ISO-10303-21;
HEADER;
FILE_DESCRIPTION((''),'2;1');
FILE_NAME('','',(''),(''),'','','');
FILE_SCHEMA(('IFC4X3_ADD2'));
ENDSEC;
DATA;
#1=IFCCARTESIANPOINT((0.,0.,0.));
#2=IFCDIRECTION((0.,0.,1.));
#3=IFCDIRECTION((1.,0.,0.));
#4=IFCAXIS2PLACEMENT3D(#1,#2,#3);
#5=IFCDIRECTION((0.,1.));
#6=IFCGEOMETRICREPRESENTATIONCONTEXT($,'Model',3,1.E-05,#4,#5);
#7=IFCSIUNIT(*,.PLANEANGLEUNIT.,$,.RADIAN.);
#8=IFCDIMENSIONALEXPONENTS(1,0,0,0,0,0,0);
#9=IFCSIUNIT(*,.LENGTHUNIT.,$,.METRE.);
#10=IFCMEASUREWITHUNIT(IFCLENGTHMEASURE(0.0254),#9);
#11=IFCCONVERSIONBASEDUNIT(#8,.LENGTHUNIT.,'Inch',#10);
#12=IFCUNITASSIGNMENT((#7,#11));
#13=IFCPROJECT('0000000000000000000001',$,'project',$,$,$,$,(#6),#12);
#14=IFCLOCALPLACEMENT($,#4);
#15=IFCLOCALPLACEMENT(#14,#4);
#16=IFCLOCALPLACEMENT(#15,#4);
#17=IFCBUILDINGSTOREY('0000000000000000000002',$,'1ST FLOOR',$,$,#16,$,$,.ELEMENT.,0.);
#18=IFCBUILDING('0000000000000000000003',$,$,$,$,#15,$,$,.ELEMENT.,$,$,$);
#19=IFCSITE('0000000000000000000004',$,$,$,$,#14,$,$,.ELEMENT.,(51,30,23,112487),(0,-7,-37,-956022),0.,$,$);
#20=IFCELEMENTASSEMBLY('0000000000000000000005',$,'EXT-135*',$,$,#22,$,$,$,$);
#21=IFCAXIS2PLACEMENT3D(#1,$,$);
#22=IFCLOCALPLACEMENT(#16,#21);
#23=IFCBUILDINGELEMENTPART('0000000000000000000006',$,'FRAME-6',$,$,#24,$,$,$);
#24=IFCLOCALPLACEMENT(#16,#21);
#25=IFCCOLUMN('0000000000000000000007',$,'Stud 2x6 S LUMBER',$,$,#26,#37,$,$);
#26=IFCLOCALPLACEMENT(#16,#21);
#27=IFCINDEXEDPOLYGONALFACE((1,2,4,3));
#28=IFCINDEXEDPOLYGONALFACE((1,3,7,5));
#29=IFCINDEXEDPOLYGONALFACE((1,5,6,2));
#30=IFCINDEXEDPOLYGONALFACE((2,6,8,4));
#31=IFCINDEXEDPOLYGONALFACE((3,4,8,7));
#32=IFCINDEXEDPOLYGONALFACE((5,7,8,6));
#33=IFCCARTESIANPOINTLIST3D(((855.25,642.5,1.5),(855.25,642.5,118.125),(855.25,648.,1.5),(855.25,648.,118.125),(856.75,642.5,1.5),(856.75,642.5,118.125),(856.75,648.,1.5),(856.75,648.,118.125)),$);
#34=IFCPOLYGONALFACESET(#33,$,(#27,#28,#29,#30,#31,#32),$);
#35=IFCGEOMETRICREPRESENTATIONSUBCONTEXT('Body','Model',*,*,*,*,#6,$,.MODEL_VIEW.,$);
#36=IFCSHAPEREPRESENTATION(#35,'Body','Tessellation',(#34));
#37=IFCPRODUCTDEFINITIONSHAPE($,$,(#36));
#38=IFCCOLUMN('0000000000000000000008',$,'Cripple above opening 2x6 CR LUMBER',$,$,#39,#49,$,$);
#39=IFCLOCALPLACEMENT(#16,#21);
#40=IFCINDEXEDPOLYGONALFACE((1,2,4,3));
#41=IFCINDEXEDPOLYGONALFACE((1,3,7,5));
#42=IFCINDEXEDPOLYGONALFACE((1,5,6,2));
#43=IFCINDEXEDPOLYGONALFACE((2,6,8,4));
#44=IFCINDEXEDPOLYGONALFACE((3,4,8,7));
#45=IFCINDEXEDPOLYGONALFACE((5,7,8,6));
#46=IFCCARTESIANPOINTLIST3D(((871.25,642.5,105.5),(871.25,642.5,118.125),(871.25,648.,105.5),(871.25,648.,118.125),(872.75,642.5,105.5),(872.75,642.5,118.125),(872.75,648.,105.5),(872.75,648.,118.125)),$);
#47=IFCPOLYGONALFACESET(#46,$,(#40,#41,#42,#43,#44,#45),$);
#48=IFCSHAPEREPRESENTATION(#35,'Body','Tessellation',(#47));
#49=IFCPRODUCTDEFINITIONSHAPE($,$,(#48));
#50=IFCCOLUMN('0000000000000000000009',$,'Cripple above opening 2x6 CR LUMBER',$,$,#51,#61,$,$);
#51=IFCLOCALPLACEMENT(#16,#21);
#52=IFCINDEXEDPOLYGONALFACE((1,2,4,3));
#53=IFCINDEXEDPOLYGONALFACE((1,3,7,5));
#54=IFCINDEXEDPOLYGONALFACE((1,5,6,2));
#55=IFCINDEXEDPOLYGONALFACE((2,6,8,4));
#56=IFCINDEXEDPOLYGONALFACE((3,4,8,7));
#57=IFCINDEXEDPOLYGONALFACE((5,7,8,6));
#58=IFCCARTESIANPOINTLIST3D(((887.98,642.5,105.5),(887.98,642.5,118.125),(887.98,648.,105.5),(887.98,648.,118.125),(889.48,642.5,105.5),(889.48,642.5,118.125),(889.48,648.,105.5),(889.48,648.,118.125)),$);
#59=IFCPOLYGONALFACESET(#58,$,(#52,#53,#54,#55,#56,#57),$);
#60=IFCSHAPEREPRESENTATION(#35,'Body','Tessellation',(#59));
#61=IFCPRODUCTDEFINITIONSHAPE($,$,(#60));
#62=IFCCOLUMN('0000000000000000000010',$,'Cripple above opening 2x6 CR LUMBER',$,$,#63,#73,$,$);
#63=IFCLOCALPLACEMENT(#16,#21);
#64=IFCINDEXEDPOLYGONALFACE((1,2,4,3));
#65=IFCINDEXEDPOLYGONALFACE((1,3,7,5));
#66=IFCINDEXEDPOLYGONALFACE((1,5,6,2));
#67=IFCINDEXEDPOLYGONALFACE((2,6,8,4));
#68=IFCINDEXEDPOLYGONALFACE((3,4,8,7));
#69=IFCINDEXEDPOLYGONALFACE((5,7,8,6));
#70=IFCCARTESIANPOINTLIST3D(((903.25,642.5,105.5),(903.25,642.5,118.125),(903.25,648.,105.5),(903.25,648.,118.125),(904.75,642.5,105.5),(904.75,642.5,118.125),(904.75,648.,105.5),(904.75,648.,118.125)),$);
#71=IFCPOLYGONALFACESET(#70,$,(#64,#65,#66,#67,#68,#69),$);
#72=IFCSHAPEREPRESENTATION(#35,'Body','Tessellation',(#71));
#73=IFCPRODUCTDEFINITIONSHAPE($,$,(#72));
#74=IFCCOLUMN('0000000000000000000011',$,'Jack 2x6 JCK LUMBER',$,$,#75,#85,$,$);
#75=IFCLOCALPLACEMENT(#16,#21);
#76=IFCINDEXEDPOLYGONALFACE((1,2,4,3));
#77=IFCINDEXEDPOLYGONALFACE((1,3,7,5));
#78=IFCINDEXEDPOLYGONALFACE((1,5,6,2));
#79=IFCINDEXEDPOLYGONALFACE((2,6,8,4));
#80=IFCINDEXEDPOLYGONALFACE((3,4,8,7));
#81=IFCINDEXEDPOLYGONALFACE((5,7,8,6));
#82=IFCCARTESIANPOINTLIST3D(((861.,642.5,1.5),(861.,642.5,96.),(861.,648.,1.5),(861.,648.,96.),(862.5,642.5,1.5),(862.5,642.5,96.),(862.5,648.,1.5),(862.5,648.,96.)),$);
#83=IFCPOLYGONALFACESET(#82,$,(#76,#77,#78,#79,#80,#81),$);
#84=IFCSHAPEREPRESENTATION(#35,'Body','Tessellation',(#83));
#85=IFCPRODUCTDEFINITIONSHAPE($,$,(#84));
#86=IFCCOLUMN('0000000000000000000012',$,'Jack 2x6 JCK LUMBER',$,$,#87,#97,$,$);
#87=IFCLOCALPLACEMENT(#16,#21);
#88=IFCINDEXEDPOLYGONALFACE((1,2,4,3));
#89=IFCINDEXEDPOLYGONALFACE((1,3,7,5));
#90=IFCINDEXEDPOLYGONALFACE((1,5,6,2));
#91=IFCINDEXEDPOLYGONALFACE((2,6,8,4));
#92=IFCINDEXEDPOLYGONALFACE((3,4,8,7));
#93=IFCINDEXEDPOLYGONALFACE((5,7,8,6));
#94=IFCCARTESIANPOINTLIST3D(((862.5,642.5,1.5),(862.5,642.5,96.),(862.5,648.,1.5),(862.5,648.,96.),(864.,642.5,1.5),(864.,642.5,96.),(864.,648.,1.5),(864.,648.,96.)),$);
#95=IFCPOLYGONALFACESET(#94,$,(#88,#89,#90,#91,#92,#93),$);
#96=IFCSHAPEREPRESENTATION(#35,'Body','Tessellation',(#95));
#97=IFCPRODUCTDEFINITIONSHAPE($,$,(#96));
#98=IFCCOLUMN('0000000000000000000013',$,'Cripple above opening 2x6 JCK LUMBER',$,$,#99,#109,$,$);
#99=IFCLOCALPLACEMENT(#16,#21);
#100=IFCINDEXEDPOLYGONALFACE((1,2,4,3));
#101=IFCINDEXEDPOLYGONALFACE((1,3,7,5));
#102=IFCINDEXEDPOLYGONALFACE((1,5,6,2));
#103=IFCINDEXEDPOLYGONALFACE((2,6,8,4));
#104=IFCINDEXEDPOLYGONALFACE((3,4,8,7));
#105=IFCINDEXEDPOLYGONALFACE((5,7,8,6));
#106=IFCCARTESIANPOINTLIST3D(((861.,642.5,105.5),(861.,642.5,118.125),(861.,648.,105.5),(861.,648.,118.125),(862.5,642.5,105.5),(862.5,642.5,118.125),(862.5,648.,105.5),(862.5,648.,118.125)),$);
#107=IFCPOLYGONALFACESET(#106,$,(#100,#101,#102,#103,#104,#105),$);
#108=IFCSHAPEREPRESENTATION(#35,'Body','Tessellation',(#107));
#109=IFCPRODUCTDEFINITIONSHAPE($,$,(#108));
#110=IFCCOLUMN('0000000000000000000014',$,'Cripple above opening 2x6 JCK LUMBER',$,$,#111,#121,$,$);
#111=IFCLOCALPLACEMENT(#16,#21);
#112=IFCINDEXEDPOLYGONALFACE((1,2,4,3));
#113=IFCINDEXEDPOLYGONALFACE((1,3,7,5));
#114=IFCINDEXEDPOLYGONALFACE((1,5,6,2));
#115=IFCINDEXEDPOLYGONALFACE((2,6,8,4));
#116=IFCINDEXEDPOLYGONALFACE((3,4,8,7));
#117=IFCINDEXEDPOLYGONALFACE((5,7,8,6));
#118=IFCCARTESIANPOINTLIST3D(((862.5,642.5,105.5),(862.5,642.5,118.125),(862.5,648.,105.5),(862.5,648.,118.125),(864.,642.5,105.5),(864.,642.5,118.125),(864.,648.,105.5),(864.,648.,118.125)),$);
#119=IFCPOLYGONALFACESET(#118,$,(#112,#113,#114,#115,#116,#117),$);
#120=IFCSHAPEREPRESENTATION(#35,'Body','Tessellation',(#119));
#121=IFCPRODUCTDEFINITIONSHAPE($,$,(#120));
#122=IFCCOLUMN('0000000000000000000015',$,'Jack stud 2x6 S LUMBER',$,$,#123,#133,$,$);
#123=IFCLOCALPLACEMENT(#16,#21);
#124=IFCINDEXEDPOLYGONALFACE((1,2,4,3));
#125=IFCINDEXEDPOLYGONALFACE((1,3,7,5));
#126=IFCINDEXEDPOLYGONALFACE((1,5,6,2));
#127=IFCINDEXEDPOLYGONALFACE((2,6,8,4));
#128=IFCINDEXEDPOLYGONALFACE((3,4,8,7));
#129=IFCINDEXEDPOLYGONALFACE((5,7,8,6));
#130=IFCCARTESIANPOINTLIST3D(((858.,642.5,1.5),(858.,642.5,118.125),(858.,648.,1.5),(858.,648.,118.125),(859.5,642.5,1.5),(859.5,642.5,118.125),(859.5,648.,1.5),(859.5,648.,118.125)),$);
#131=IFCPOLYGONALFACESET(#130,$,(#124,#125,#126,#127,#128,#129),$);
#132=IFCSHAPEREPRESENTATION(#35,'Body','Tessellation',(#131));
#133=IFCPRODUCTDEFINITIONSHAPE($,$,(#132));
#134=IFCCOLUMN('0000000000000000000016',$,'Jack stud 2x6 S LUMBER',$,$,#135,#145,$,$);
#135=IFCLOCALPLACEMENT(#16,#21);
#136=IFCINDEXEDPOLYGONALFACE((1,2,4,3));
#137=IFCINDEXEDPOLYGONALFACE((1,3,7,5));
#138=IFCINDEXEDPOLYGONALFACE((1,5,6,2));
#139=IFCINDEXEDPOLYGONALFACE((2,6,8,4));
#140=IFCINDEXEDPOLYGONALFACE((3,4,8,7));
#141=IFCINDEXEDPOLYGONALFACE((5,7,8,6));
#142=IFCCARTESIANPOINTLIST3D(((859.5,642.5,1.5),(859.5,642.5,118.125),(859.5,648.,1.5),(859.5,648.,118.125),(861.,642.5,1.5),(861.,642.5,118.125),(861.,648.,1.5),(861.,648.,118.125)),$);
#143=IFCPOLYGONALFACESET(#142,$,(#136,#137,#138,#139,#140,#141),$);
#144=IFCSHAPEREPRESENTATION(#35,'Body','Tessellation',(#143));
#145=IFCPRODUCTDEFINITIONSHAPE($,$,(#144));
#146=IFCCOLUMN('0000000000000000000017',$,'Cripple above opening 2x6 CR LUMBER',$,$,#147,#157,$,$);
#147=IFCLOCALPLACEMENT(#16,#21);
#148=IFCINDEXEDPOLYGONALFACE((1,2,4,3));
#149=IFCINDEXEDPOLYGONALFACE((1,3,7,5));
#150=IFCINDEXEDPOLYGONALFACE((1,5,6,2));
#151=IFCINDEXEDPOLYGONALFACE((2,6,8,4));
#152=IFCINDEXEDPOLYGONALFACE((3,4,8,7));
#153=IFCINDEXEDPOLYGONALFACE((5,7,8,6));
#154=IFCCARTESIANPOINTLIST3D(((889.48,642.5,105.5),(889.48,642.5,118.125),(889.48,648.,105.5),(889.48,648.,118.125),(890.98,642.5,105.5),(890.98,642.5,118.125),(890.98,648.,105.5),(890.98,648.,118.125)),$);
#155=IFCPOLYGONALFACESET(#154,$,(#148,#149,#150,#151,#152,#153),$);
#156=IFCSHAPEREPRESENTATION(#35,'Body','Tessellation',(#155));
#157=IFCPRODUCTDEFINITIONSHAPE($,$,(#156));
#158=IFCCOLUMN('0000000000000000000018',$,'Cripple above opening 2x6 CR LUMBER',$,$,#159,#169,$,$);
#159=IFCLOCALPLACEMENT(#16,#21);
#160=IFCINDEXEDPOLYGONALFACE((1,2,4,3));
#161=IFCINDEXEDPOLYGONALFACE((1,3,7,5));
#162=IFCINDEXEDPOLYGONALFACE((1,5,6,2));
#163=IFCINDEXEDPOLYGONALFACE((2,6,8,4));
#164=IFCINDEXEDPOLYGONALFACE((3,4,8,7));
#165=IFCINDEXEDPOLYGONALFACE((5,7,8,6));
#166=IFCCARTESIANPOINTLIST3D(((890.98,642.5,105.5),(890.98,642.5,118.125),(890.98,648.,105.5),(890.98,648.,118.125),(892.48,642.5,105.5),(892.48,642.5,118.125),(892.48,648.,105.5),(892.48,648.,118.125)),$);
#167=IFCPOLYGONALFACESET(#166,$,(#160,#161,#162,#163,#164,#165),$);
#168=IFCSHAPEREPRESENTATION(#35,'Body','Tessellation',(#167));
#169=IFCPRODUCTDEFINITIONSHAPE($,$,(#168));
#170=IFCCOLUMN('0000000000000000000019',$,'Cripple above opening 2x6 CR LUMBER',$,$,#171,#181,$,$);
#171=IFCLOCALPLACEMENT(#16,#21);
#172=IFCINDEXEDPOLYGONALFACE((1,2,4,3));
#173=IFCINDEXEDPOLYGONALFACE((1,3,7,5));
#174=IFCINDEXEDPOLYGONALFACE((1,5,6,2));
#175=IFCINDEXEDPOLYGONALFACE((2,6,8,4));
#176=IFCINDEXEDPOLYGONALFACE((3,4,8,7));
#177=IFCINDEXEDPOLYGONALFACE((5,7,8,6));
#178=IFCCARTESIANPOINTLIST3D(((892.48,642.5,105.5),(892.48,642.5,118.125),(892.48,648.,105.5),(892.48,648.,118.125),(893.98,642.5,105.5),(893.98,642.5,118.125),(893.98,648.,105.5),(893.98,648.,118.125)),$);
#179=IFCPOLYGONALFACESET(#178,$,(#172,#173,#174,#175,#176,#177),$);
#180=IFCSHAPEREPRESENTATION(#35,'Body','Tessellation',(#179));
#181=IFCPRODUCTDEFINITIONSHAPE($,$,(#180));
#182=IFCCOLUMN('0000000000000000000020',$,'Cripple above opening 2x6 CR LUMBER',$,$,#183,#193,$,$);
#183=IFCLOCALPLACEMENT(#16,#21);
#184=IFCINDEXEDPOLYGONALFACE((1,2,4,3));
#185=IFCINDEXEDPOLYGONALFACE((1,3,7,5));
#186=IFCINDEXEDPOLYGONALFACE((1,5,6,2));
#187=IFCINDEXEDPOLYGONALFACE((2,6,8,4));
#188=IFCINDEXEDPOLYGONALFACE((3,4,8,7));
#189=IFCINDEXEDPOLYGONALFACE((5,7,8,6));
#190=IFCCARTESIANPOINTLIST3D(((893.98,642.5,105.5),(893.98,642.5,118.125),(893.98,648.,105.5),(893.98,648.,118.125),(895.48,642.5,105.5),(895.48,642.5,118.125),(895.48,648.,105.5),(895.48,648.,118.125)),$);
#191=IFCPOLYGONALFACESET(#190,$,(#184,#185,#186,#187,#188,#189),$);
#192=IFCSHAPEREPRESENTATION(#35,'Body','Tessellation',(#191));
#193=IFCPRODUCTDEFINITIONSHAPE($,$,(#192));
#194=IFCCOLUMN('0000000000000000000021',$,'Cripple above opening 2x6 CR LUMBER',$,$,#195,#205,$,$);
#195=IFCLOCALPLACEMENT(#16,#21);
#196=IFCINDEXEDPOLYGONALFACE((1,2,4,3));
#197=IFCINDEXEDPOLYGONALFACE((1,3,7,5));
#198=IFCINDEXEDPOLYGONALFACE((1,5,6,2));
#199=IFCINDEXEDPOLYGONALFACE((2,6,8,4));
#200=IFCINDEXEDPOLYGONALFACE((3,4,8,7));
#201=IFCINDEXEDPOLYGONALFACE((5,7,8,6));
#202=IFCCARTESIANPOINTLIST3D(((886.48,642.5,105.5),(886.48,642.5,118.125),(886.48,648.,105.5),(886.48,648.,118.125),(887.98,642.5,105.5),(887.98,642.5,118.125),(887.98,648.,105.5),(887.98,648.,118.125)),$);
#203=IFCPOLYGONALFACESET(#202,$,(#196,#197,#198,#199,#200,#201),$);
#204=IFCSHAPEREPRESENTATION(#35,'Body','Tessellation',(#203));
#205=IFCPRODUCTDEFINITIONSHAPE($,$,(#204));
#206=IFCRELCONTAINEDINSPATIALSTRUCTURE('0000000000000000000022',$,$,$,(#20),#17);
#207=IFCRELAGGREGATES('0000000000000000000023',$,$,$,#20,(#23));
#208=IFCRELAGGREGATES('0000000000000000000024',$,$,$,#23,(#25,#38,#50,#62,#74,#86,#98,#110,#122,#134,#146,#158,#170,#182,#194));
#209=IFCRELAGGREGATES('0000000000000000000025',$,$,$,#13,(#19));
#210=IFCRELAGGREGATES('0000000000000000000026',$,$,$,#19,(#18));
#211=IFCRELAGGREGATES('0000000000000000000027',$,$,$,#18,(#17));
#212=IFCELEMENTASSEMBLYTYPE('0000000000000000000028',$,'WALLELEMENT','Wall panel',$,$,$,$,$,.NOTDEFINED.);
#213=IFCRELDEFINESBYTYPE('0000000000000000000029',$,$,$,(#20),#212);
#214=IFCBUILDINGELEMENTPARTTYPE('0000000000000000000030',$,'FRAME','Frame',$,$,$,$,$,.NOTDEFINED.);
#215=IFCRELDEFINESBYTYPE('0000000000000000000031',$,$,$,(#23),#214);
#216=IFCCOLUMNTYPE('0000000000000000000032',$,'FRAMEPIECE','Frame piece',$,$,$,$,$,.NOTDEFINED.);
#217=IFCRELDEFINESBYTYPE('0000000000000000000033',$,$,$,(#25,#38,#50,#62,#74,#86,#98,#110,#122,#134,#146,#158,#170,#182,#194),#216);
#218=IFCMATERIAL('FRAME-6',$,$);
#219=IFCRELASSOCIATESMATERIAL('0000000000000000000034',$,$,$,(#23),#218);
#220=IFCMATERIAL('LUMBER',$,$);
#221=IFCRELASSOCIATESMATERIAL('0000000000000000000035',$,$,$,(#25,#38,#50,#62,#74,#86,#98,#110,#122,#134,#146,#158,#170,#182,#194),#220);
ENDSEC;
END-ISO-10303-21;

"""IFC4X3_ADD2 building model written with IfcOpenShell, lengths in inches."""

from ifc_helpers import new_model, entity, si_unit, converted_unit, direction, frame, origin_with_axes, origin_2d_with_axis, place, context, subcontext, project, spatial, rectangle, extrude, material, type_object, element, aggregate, save


model = new_model("IFC4X3_ADD2")

# Units and contexts
model_context = context("Model", 3, precision=1e-05, world=origin_with_axes(), true_north=direction((0.0, 1.0)))
body_context = subcontext(model_context, "Body", "Model", "MODEL_VIEW")
ifc_project = project(units=[si_unit("PLANEANGLEUNIT", "RADIAN"), converted_unit("LENGTHUNIT", "Inch", entity("IfcLengthMeasure", 0.0254), si_unit("LENGTHUNIT", "METRE"), dimensions=[1, 0, 0, 0, 0, 0, 0])], contexts=[model_context])

# Site, building, storey
site_placement = place(None, origin_with_axes())
site = spatial("IfcSite", under=ifc_project, at=site_placement, CompositionType="ELEMENT", RefLatitude=(51, 30, 23, 112487), RefLongitude=(0, -7, -37, -956022), RefElevation=0.0)
building_placement = place(site_placement, origin_with_axes())
building = spatial("IfcBuilding", under=site, at=building_placement, CompositionType="ELEMENT")
storey_placement = place(building_placement, origin_with_axes())
storey = spatial("IfcBuildingStorey", under=building, at=storey_placement, Name="1ST FLOOR", CompositionType="ELEMENT", Elevation=0.0)

# Element assembly, building element part, columns
element_assembly_type_1 = type_object("IfcElementAssemblyType", Name="WALLELEMENT", Description="Wall panel", PredefinedType="NOTDEFINED")
assembly_1_placement = place(storey_placement, origin_with_axes())
assembly_1 = element("IfcElementAssembly", 1, at=assembly_1_placement, inside=storey, type_object=element_assembly_type_1, Name="EXT-135*")
ifc_material_1 = material(Name="FRAME-6")
building_element_part_type = type_object("IfcBuildingElementPartType", Name="FRAME", Description="Frame", PredefinedType="NOTDEFINED")
building_element_part_1_placement = place(storey_placement, origin_with_axes())
building_element_part_1 = element("IfcBuildingElementPart", 2, at=building_element_part_1_placement, type_object=building_element_part_type, material=ifc_material_1, Name="FRAME-6")
aggregate(assembly_1, [building_element_part_1])
ifc_material_2 = material(Name="LUMBER")
column_type = type_object("IfcColumnType", Name="FRAMEPIECE", Description="Frame piece", PredefinedType="NOTDEFINED")
column_1_placement = place(storey_placement, frame((856.0, 645.25, 118.125), z_axis=(0.0, 0.0, -1.0), x_axis=(-1.0, 0.0, 0.0)))
column_1 = element("IfcColumn", 3, at=column_1_placement, type_object=column_type, material=ifc_material_2, Name="Stud 2x6 S LUMBER", context=body_context, shape_type="SweptSolid", body=[
    extrude(rectangle(XDim=1.5, YDim=5.5, at=origin_2d_with_axis()), origin_with_axes(), (0.0, 0.0, 1.0), 116.625),
])
column_2_placement = place(storey_placement, frame((872.0, 645.25, 118.125), z_axis=(0.0, 0.0, -1.0), x_axis=(-1.0, 0.0, 0.0)))
column_2 = element("IfcColumn", 4, at=column_2_placement, type_object=column_type, material=ifc_material_2, Name="Cripple above opening 2x6 CR LUMBER", context=body_context, shape_type="SweptSolid", body=[
    extrude(rectangle(XDim=1.5, YDim=5.5, at=origin_2d_with_axis()), origin_with_axes(), (0.0, 0.0, 1.0), 12.625),
])
column_3_placement = place(storey_placement, frame((888.73, 645.25, 118.125), z_axis=(0.0, 0.0, -1.0), x_axis=(-1.0, 0.0, 0.0)))
column_3 = element("IfcColumn", 5, at=column_3_placement, type_object=column_type, material=ifc_material_2, Name="Cripple above opening 2x6 CR LUMBER", context=body_context, shape_type="SweptSolid", body=[
    extrude(rectangle(XDim=1.5, YDim=5.5, at=origin_2d_with_axis()), origin_with_axes(), (0.0, 0.0, 1.0), 12.625),
])
column_4_placement = place(storey_placement, frame((904.0, 645.25, 118.125), z_axis=(0.0, 0.0, -1.0), x_axis=(-1.0, 0.0, 0.0)))
column_4 = element("IfcColumn", 6, at=column_4_placement, type_object=column_type, material=ifc_material_2, Name="Cripple above opening 2x6 CR LUMBER", context=body_context, shape_type="SweptSolid", body=[
    extrude(rectangle(XDim=1.5, YDim=5.5, at=origin_2d_with_axis()), origin_with_axes(), (0.0, 0.0, 1.0), 12.625),
])
column_5_placement = place(storey_placement, frame((861.75, 645.25, 1.5), z_axis=(0.0, 0.0, 1.0), x_axis=(1.0, 0.0, 0.0)))
column_5 = element("IfcColumn", 7, at=column_5_placement, type_object=column_type, material=ifc_material_2, Name="Jack 2x6 JCK LUMBER", context=body_context, shape_type="SweptSolid", body=[
    extrude(rectangle(XDim=1.5, YDim=5.5, at=origin_2d_with_axis()), origin_with_axes(), (0.0, 0.0, 1.0), 94.5),
])
column_6_placement = place(storey_placement, frame((863.25, 645.25, 1.5), z_axis=(0.0, 0.0, 1.0), x_axis=(1.0, 0.0, 0.0)))
column_6 = element("IfcColumn", 8, at=column_6_placement, type_object=column_type, material=ifc_material_2, Name="Jack 2x6 JCK LUMBER", context=body_context, shape_type="SweptSolid", body=[
    extrude(rectangle(XDim=1.5, YDim=5.5, at=origin_2d_with_axis()), origin_with_axes(), (0.0, 0.0, 1.0), 94.5),
])
column_7_placement = place(storey_placement, frame((861.75, 645.25, 105.5), z_axis=(0.0, 0.0, 1.0), x_axis=(1.0, 0.0, 0.0)))
column_7 = element("IfcColumn", 9, at=column_7_placement, type_object=column_type, material=ifc_material_2, Name="Cripple above opening 2x6 JCK LUMBER", context=body_context, shape_type="SweptSolid", body=[
    extrude(rectangle(XDim=1.5, YDim=5.5, at=origin_2d_with_axis()), origin_with_axes(), (0.0, 0.0, 1.0), 12.625),
])
column_8_placement = place(storey_placement, frame((863.25, 645.25, 105.5), z_axis=(0.0, 0.0, 1.0), x_axis=(1.0, 0.0, 0.0)))
column_8 = element("IfcColumn", 10, at=column_8_placement, type_object=column_type, material=ifc_material_2, Name="Cripple above opening 2x6 JCK LUMBER", context=body_context, shape_type="SweptSolid", body=[
    extrude(rectangle(XDim=1.5, YDim=5.5, at=origin_2d_with_axis()), origin_with_axes(), (0.0, 0.0, 1.0), 12.625),
])
column_9_placement = place(storey_placement, frame((858.75, 645.25, 1.5), z_axis=(0.0, 0.0, 1.0), x_axis=(1.0, 0.0, 0.0)))
column_9 = element("IfcColumn", 11, at=column_9_placement, type_object=column_type, material=ifc_material_2, Name="Jack stud 2x6 S LUMBER", context=body_context, shape_type="SweptSolid", body=[
    extrude(rectangle(XDim=1.5, YDim=5.5, at=origin_2d_with_axis()), origin_with_axes(), (0.0, 0.0, 1.0), 116.625),
])
column_10_placement = place(storey_placement, frame((860.25, 645.25, 1.5), z_axis=(0.0, 0.0, 1.0), x_axis=(1.0, 0.0, 0.0)))
column_10 = element("IfcColumn", 12, at=column_10_placement, type_object=column_type, material=ifc_material_2, Name="Jack stud 2x6 S LUMBER", context=body_context, shape_type="SweptSolid", body=[
    extrude(rectangle(XDim=1.5, YDim=5.5, at=origin_2d_with_axis()), origin_with_axes(), (0.0, 0.0, 1.0), 116.625),
])
column_11_placement = place(storey_placement, frame((890.23, 645.25, 105.5), z_axis=(0.0, 0.0, 1.0), x_axis=(1.0, 0.0, 0.0)))
column_11 = element("IfcColumn", 13, at=column_11_placement, type_object=column_type, material=ifc_material_2, Name="Cripple above opening 2x6 CR LUMBER", context=body_context, shape_type="SweptSolid", body=[
    extrude(rectangle(XDim=1.5, YDim=5.5, at=origin_2d_with_axis()), origin_with_axes(), (0.0, 0.0, 1.0), 12.625),
])
column_12_placement = place(storey_placement, frame((891.73, 645.25, 118.125), z_axis=(0.0, 0.0, -1.0), x_axis=(-1.0, 0.0, 0.0)))
column_12 = element("IfcColumn", 14, at=column_12_placement, type_object=column_type, material=ifc_material_2, Name="Cripple above opening 2x6 CR LUMBER", context=body_context, shape_type="SweptSolid", body=[
    extrude(rectangle(XDim=1.5, YDim=5.5, at=origin_2d_with_axis()), origin_with_axes(), (0.0, 0.0, 1.0), 12.625),
])
column_13_placement = place(storey_placement, frame((893.23, 645.25, 105.5), z_axis=(0.0, 0.0, 1.0), x_axis=(1.0, 0.0, 0.0)))
column_13 = element("IfcColumn", 15, at=column_13_placement, type_object=column_type, material=ifc_material_2, Name="Cripple above opening 2x6 CR LUMBER", context=body_context, shape_type="SweptSolid", body=[
    extrude(rectangle(XDim=1.5, YDim=5.5, at=origin_2d_with_axis()), origin_with_axes(), (0.0, 0.0, 1.0), 12.625),
])
column_14_placement = place(storey_placement, frame((894.73, 645.25, 118.125), z_axis=(0.0, 0.0, -1.0), x_axis=(-1.0, 0.0, 0.0)))
column_14 = element("IfcColumn", 16, at=column_14_placement, type_object=column_type, material=ifc_material_2, Name="Cripple above opening 2x6 CR LUMBER", context=body_context, shape_type="SweptSolid", body=[
    extrude(rectangle(XDim=1.5, YDim=5.5, at=origin_2d_with_axis()), origin_with_axes(), (0.0, 0.0, 1.0), 12.625),
])
column_15_placement = place(storey_placement, frame((887.23, 645.25, 105.5), z_axis=(0.0, 0.0, 1.0), x_axis=(1.0, 0.0, 0.0)))
column_15 = element("IfcColumn", 17, at=column_15_placement, type_object=column_type, material=ifc_material_2, Name="Cripple above opening 2x6 CR LUMBER", context=body_context, shape_type="SweptSolid", body=[
    extrude(rectangle(XDim=1.5, YDim=5.5, at=origin_2d_with_axis()), origin_with_axes(), (0.0, 0.0, 1.0), 12.625),
])
aggregate(building_element_part_1, [column_1, column_2, column_3, column_4, column_5, column_6, column_7, column_8, column_9, column_10, column_11, column_12, column_13, column_14, column_15])

save(model, "model.ifc")
